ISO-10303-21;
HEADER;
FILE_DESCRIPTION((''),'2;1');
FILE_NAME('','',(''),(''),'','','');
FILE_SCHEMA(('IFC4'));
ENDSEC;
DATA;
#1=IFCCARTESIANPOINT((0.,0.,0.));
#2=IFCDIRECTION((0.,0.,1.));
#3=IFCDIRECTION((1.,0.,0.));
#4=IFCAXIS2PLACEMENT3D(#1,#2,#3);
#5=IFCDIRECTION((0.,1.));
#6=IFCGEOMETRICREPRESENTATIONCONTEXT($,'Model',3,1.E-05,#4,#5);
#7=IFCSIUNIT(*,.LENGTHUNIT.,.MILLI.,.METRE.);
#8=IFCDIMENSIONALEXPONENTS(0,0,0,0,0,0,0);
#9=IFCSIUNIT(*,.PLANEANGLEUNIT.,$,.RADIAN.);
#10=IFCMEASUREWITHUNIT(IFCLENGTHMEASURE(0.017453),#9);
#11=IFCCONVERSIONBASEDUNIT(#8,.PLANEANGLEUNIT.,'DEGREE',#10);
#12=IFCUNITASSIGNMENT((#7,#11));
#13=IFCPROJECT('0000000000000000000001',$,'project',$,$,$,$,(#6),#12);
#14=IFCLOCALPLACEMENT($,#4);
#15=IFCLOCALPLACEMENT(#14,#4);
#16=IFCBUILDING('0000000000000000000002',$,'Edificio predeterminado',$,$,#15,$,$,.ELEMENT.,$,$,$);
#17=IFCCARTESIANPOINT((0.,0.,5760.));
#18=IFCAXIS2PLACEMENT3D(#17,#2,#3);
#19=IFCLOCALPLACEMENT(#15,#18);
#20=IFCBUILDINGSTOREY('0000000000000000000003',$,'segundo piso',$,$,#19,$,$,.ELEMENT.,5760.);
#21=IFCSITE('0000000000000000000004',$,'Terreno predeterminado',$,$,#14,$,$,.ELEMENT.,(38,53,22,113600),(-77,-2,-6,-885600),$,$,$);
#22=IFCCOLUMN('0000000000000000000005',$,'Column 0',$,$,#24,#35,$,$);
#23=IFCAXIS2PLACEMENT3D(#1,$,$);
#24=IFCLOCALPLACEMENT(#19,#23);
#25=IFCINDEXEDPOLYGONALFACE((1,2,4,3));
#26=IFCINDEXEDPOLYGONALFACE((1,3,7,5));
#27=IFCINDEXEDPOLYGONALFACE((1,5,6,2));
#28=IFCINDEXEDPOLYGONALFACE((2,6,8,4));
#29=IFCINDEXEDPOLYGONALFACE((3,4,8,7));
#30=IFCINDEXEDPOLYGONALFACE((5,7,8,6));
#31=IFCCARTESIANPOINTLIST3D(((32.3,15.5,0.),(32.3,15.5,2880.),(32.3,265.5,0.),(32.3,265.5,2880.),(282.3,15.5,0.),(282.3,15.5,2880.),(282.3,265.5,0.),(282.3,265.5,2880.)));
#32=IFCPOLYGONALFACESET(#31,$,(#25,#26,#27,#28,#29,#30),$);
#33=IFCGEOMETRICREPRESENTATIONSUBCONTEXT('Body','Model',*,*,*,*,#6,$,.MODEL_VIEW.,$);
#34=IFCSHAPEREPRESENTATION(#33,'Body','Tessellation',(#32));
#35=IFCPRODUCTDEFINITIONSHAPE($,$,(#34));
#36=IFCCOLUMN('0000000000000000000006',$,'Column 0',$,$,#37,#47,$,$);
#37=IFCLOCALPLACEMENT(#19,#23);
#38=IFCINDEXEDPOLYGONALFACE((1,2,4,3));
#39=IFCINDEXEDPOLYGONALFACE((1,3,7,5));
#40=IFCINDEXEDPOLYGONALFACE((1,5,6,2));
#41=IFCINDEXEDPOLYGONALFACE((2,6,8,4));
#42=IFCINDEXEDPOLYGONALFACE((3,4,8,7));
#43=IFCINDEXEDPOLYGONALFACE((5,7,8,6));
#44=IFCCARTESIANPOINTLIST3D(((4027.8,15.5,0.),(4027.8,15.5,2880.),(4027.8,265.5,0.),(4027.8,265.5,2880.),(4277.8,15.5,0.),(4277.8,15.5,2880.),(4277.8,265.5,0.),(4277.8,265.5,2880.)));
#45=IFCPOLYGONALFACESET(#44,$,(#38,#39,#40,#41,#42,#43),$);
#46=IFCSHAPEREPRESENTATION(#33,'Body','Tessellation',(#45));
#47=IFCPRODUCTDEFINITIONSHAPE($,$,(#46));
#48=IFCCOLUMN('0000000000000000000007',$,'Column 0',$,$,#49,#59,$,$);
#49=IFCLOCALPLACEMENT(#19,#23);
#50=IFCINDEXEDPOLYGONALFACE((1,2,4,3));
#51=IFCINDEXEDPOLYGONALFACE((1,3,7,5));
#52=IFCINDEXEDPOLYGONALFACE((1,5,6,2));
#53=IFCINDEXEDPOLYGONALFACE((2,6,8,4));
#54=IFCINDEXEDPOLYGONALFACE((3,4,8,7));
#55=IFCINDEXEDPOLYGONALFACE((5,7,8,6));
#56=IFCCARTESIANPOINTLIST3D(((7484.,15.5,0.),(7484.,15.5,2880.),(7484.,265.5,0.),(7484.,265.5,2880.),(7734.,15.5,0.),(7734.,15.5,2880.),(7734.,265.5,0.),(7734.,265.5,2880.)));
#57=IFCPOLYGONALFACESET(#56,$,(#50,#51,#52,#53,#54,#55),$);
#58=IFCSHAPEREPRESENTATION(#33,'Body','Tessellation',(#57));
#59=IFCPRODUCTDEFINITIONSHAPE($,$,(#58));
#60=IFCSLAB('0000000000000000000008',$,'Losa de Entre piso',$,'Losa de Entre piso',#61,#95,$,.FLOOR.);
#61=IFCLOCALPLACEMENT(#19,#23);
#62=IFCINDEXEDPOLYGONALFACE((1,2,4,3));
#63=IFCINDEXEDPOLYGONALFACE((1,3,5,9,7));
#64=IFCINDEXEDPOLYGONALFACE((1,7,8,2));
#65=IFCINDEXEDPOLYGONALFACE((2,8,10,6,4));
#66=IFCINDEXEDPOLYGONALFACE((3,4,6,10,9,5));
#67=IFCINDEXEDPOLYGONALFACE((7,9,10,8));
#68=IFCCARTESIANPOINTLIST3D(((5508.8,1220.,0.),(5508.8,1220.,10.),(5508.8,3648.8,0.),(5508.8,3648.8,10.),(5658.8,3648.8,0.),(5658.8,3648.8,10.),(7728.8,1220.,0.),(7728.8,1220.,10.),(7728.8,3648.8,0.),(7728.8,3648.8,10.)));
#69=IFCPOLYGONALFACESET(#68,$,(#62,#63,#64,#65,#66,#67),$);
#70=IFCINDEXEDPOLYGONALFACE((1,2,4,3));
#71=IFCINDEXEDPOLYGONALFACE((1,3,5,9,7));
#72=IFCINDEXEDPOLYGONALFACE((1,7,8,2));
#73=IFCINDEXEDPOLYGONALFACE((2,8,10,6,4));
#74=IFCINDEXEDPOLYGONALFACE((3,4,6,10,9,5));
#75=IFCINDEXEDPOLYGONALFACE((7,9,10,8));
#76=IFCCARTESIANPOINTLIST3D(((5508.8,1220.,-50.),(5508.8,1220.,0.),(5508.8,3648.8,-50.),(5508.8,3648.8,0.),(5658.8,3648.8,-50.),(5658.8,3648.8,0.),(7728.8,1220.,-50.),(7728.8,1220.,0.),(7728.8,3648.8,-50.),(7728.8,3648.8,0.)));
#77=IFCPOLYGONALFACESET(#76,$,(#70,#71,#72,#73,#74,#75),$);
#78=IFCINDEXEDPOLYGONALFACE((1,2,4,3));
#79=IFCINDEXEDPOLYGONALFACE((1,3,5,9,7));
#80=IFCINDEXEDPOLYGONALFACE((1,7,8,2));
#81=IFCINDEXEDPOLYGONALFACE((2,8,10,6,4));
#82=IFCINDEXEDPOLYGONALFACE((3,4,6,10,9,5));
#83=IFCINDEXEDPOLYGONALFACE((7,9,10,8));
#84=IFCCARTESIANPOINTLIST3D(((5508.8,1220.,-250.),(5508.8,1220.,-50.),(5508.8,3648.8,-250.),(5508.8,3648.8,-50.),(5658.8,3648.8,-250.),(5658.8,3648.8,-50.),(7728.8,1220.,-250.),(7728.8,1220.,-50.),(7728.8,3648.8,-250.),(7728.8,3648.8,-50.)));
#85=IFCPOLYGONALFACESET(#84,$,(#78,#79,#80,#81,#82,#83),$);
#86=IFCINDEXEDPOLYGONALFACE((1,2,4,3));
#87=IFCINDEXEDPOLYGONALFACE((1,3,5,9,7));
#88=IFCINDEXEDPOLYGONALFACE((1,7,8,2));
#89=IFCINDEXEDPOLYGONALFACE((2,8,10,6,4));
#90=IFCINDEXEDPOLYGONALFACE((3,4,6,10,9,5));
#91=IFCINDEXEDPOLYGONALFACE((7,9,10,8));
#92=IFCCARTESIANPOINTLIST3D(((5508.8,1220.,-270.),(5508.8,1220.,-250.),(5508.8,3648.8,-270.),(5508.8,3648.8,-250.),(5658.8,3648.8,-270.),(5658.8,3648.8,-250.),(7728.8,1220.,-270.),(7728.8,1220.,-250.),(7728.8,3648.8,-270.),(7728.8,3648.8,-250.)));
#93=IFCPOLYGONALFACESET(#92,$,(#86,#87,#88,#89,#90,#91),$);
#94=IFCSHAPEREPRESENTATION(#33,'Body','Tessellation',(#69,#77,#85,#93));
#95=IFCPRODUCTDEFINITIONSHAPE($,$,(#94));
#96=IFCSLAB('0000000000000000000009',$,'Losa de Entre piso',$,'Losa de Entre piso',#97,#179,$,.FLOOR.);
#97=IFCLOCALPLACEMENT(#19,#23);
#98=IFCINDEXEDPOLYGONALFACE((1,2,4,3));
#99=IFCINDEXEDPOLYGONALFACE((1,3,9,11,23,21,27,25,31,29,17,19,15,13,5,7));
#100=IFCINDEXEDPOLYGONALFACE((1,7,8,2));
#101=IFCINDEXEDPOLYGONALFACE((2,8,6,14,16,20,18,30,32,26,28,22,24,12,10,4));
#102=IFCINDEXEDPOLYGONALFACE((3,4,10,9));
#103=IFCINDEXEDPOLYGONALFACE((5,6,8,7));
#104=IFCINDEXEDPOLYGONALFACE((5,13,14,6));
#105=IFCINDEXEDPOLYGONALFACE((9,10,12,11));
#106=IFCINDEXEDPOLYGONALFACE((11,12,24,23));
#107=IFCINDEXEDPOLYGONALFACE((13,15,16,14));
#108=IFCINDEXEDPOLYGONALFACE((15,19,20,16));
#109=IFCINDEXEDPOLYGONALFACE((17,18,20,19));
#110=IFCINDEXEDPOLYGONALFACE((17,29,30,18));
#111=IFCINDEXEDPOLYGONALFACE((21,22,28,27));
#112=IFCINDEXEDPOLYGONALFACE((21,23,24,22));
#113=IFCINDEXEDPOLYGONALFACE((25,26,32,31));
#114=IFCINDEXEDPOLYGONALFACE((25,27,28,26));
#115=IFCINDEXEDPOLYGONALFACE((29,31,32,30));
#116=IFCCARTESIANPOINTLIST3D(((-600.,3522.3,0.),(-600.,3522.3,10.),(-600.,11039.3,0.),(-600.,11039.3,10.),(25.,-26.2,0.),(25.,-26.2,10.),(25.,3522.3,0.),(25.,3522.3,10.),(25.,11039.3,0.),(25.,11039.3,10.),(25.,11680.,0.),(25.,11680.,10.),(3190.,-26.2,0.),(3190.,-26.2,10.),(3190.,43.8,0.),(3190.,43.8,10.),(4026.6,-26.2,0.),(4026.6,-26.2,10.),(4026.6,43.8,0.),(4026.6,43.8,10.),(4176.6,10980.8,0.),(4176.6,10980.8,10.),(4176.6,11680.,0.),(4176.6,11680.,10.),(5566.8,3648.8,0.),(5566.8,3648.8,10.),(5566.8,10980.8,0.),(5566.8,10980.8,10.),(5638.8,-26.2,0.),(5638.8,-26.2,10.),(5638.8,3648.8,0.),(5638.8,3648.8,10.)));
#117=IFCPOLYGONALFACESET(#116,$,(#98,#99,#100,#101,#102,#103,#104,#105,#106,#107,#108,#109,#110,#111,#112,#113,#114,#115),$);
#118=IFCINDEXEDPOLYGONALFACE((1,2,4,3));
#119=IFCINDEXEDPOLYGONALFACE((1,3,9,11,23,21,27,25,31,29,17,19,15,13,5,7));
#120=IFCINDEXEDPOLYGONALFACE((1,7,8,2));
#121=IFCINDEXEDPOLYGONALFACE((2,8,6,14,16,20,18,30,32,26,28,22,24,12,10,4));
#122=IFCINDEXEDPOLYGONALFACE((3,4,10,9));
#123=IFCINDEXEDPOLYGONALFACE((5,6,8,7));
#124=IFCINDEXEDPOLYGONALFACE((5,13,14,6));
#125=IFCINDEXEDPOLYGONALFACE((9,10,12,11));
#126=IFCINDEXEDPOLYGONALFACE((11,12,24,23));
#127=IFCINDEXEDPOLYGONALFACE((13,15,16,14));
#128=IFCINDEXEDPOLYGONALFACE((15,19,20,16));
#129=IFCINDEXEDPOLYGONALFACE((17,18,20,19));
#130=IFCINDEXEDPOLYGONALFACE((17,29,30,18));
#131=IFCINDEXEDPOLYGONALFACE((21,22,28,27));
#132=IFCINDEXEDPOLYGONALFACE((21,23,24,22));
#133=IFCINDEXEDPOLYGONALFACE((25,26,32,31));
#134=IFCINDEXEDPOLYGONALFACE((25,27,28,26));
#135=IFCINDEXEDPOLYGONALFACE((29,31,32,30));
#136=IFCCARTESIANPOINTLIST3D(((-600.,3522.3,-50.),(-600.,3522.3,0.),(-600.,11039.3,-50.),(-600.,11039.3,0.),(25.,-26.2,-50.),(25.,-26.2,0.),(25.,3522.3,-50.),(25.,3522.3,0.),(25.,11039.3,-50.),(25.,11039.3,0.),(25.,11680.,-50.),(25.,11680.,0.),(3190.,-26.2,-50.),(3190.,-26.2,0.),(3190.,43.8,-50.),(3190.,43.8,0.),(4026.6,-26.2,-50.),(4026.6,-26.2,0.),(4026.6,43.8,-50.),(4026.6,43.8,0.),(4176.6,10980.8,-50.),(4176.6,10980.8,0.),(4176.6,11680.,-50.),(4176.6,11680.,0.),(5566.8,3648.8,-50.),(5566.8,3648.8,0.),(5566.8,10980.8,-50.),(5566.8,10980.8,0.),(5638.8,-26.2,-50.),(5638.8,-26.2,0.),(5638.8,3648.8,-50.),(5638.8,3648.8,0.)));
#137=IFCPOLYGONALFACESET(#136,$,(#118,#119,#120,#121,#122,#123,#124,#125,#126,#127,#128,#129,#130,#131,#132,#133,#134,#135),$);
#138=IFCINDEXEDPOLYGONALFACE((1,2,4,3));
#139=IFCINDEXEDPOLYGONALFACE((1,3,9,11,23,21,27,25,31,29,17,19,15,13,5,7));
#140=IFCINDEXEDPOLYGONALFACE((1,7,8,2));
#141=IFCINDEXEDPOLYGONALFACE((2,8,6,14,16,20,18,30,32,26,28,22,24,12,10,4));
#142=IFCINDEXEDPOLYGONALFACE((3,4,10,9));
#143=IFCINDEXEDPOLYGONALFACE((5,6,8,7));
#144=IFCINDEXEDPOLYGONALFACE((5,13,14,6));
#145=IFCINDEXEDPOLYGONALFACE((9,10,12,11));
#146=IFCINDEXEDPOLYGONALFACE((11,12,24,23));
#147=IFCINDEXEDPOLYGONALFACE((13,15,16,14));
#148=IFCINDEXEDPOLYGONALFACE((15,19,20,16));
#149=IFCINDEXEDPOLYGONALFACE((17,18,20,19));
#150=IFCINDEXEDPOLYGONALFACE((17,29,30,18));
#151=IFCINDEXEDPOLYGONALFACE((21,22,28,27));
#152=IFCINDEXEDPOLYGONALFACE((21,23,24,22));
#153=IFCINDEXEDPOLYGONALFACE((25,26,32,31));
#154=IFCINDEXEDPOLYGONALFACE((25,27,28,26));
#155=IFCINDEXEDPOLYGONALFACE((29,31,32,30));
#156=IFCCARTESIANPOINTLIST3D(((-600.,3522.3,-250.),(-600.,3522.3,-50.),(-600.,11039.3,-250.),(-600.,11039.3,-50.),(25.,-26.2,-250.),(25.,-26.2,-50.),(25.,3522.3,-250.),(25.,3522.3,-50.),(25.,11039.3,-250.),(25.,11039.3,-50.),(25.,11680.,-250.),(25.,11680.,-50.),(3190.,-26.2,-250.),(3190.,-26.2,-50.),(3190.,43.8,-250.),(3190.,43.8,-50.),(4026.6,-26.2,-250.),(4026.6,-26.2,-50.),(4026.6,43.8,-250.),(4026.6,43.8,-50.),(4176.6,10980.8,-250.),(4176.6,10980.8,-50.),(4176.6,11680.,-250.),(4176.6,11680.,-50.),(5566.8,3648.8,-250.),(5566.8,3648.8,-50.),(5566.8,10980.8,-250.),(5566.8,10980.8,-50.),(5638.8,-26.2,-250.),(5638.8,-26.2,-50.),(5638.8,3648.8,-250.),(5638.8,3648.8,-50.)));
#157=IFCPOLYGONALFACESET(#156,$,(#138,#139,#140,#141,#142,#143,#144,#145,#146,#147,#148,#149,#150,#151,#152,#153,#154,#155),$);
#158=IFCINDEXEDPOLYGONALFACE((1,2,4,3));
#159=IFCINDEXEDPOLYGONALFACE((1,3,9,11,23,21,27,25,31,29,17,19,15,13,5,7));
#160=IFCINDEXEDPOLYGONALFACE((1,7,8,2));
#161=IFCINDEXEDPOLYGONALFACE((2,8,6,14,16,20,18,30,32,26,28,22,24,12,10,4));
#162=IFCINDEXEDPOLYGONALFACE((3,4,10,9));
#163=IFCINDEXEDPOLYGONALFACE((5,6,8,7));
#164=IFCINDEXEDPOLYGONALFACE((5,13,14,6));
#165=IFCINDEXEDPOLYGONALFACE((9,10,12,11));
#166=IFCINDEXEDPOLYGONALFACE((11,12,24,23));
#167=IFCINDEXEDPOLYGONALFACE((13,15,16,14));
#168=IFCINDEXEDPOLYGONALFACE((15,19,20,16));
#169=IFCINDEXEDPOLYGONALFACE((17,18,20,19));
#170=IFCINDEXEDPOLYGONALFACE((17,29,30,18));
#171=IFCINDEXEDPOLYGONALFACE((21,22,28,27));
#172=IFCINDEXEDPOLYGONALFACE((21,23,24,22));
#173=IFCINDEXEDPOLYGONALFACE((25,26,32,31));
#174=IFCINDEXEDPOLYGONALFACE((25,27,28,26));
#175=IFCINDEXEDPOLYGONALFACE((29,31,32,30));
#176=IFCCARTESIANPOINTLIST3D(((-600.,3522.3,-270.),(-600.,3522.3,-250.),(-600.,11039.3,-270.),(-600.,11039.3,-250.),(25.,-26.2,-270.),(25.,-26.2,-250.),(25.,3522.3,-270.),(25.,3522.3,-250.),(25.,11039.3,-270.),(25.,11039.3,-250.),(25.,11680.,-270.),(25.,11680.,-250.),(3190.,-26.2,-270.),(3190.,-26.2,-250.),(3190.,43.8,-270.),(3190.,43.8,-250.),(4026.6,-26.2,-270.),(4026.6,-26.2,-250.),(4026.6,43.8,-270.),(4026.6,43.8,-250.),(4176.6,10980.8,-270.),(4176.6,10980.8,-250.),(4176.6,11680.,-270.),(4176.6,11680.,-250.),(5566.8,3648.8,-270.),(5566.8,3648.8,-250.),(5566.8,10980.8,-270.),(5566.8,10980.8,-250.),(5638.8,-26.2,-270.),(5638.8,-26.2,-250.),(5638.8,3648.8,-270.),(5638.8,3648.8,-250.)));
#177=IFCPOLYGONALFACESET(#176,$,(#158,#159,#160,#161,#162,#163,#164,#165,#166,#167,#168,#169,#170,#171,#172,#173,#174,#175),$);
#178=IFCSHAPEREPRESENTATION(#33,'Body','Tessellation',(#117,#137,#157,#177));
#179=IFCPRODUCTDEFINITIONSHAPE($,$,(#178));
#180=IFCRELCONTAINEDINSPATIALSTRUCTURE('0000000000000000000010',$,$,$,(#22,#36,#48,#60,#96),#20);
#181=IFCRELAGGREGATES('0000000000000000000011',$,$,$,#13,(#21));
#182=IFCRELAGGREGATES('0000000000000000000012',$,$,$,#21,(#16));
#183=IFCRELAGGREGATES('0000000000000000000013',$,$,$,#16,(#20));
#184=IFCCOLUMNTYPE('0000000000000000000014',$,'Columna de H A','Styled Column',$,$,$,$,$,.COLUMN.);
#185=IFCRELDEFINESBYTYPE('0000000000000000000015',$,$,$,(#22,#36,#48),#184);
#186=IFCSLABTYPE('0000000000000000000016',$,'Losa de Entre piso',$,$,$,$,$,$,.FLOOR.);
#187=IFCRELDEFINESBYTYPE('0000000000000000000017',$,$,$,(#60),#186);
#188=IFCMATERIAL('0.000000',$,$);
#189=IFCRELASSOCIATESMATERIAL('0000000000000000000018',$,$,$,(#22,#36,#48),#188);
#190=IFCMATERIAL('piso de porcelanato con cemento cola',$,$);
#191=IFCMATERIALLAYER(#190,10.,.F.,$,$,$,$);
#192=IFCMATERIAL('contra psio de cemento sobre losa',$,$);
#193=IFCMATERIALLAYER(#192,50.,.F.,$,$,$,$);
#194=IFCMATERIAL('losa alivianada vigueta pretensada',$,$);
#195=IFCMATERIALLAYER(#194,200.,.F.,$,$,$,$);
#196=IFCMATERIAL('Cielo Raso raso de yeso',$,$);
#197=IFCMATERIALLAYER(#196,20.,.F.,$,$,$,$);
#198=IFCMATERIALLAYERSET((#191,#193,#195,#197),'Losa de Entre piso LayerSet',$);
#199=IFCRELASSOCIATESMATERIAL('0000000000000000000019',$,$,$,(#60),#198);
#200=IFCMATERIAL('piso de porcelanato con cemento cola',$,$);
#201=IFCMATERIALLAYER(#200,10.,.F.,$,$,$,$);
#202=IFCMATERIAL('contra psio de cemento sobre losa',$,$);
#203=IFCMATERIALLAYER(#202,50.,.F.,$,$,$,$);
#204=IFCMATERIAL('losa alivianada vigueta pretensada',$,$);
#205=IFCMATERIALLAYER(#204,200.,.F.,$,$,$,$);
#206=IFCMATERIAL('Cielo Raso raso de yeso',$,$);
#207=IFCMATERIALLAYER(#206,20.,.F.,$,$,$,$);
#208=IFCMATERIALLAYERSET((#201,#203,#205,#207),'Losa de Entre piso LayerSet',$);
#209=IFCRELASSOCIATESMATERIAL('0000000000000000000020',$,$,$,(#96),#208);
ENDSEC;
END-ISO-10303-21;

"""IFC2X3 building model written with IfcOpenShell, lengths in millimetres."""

from ifc_helpers import new_model, entity, si_unit, converted_unit, direction, frame, origin_with_axes, place, context, subcontext, project, spatial, polyline, outline, extrude, material, layer, layer_set, layer_usage, type_object, element, save


model = new_model("IFC2X3")

# Units and contexts
model_context = context("Model", 3, precision=1e-05, world=origin_with_axes(), true_north=direction((0.0, 1.0)))
body_context = subcontext(model_context, "Body", "Model", "MODEL_VIEW")
ifc_project = project(units=[si_unit("LENGTHUNIT", "METRE", prefix="MILLI"), converted_unit("PLANEANGLEUNIT", "DEGREE", entity("IfcLengthMeasure", 0.017453), si_unit("PLANEANGLEUNIT", "RADIAN"), dimensions=[0, 0, 0, 0, 0, 0, 0])], contexts=[model_context])

# Site, building, storey
site_placement = place(None, origin_with_axes())
site = spatial("IfcSite", under=ifc_project, at=site_placement, Name="Terreno predeterminado", CompositionType="ELEMENT", RefLatitude=(38, 53, 22, 113600), RefLongitude=(-77, -2, -6, -885600))
building_placement = place(site_placement, origin_with_axes())
building = spatial("IfcBuilding", under=site, at=building_placement, Name="Edificio predeterminado", CompositionType="ELEMENT")
storey_placement = place(building_placement, frame((0.0, 0.0, 5760.0), z_axis=(0.0, 0.0, 1.0), x_axis=(1.0, 0.0, 0.0)))
storey = spatial("IfcBuildingStorey", under=building, at=storey_placement, Name="segundo piso", CompositionType="ELEMENT", Elevation=5760.0)

# Columns
ifc_material_1 = material(Name="0.000000")
column_type = type_object("IfcColumnType", Name="Columna de H A", Description="Styled Column", PredefinedType="COLUMN")
for number, where, z_axis, x_axis, name in (
    (1, (157.3, 140.5, 0.0), (0.0, 0.0, 1.0), (1.0, 0.0, 0.0), "Column 0"),
    (2, (4152.8, 140.5, 0.0), (0.0, 0.0, 1.0), (1.0, 0.0, 0.0), "Column 0"),
    (3, (7609.0, 140.5, 0.0), (0.0, 0.0, 1.0), (1.0, 0.0, 0.0), "Column 0"),
):
    element("IfcColumn", number, at=place(storey_placement, frame(where, z_axis=z_axis, x_axis=x_axis)), inside=storey, type_object=column_type, material=ifc_material_1, Name=name, context=body_context, shape_type="SweptSolid", body=[
        extrude(outline(polyline([(-125.0, -125.0), (125.0, -125.0), (125.0, 125.0), (-125.0, 125.0), (-125.0, -125.0)])), origin_with_axes(), (0.0, 0.0, 1.0), 2880.0),
    ])

# Slabs
ifc_material_2 = material(Name="piso de porcelanato con cemento cola")
ifc_layer_1 = layer(ifc_material_2, 10.0, ventilated=False)
ifc_material_3 = material(Name="contra psio de cemento sobre losa")
ifc_layer_2 = layer(ifc_material_3, 50.0, ventilated=False)
ifc_material_4 = material(Name="losa alivianada vigueta pretensada")
ifc_layer_3 = layer(ifc_material_4, 200.0, ventilated=False)
ifc_material_5 = material(Name="Cielo Raso raso de yeso")
ifc_layer_4 = layer(ifc_material_5, 20.0, ventilated=False)
ifc_layer_set_1 = layer_set([ifc_layer_1, ifc_layer_2, ifc_layer_3, ifc_layer_4], Name="Losa de Entre piso LayerSet")
ifc_layer_usage_1 = layer_usage(ifc_layer_set_1, "AXIS3", "POSITIVE", 0.0)
slab_type = type_object("IfcSlabType", Name="Losa de Entre piso", PredefinedType="FLOOR")
slab_1_placement = place(storey_placement, frame((0.0, 0.0, -5760.0), z_axis=(0.0, 0.0, 1.0), x_axis=(1.0, 0.0, 0.0)))
element("IfcSlab", 4, at=slab_1_placement, inside=storey, type_object=slab_type, material=ifc_layer_usage_1, Name="Losa de Entre piso", ObjectType="Losa de Entre piso", PredefinedType="FLOOR", context=body_context, shape_type="SweptSolid", body=[
    extrude(outline(polyline([(0.0, 0.0), (2070.0, 0.0), (2070.0, 2428.8), (-150.0, 2428.8), (-150.0, 0.0), (0.0, 0.0)])), frame((5658.8, 3648.8, 5760.0), z_axis=(0.0, 0.0, -1.0), x_axis=(1.0, 0.0, 0.0)), (0.0, 0.0, -1.0), 10.0),
    extrude(outline(polyline([(0.0, 0.0), (2070.0, 0.0), (2070.0, 2428.8), (-150.0, 2428.8), (-150.0, 0.0), (0.0, 0.0)])), frame((5658.8, 3648.8, 5710.0), z_axis=(0.0, 0.0, -1.0), x_axis=(1.0, 0.0, 0.0)), (0.0, 0.0, -1.0), 50.0),
    extrude(outline(polyline([(0.0, 0.0), (2070.0, 0.0), (2070.0, 2428.8), (-150.0, 2428.8), (-150.0, 0.0), (0.0, 0.0)])), frame((5658.8, 3648.8, 5510.0), z_axis=(0.0, 0.0, -1.0), x_axis=(1.0, 0.0, 0.0)), (0.0, 0.0, -1.0), 200.0),
    extrude(outline(polyline([(0.0, 0.0), (2070.0, 0.0), (2070.0, 2428.8), (-150.0, 2428.8), (-150.0, 0.0), (0.0, 0.0)])), frame((5658.8, 3648.8, 5490.0), z_axis=(0.0, 0.0, -1.0), x_axis=(1.0, 0.0, 0.0)), (0.0, 0.0, -1.0), 20.0),
])
ifc_material_6 = material(Name="piso de porcelanato con cemento cola")
ifc_layer_5 = layer(ifc_material_6, 10.0, ventilated=False)
ifc_material_7 = material(Name="contra psio de cemento sobre losa")
ifc_layer_6 = layer(ifc_material_7, 50.0, ventilated=False)
ifc_material_8 = material(Name="losa alivianada vigueta pretensada")
ifc_layer_7 = layer(ifc_material_8, 200.0, ventilated=False)
ifc_material_9 = material(Name="Cielo Raso raso de yeso")
ifc_layer_8 = layer(ifc_material_9, 20.0, ventilated=False)
ifc_layer_set_2 = layer_set([ifc_layer_5, ifc_layer_6, ifc_layer_7, ifc_layer_8], Name="Losa de Entre piso LayerSet")
ifc_layer_usage_2 = layer_usage(ifc_layer_set_2, "AXIS3", "POSITIVE", 0.0)
slab_2_placement = place(storey_placement, frame((0.0, 0.0, -5760.0), z_axis=(0.0, 0.0, 1.0), x_axis=(1.0, 0.0, 0.0)))
element("IfcSlab", 5, at=slab_2_placement, inside=storey, material=ifc_layer_usage_2, Name="Losa de Entre piso", ObjectType="Losa de Entre piso", PredefinedType="FLOOR", context=body_context, shape_type="SweptSolid", body=[
    extrude(outline(polyline([(0.0, 0.0), (625.0, 0.0), (625.0, 7517.0), (0.0, 7517.0), (0.0, 8157.7), (-4151.6, 8157.7), (-4151.6, 7458.5), (-5541.8, 7458.5), (-5541.8, 126.5), (-5613.8, 126.5), (-5613.8, -3548.5), (-4001.6, -3548.5), (-4001.6, -3478.5), (-3165.0, -3478.5), (-3165.0, -3548.5), (0.0, -3548.5), (0.0, 0.0)])), frame((25.0, 3522.3, 5760.0), z_axis=(0.0, 0.0, -1.0), x_axis=(-1.0, 0.0, 0.0)), (0.0, 0.0, -1.0), 10.0),
    extrude(outline(polyline([(0.0, 0.0), (625.0, 0.0), (625.0, 7517.0), (0.0, 7517.0), (0.0, 8157.7), (-4151.6, 8157.7), (-4151.6, 7458.5), (-5541.8, 7458.5), (-5541.8, 126.5), (-5613.8, 126.5), (-5613.8, -3548.5), (-4001.6, -3548.5), (-4001.6, -3478.5), (-3165.0, -3478.5), (-3165.0, -3548.5), (0.0, -3548.5), (0.0, 0.0)])), frame((25.0, 3522.3, 5710.0), z_axis=(0.0, 0.0, -1.0), x_axis=(-1.0, 0.0, 0.0)), (0.0, 0.0, -1.0), 50.0),
    extrude(outline(polyline([(0.0, 0.0), (625.0, 0.0), (625.0, 7517.0), (0.0, 7517.0), (0.0, 8157.7), (-4151.6, 8157.7), (-4151.6, 7458.5), (-5541.8, 7458.5), (-5541.8, 126.5), (-5613.8, 126.5), (-5613.8, -3548.5), (-4001.6, -3548.5), (-4001.6, -3478.5), (-3165.0, -3478.5), (-3165.0, -3548.5), (0.0, -3548.5), (0.0, 0.0)])), frame((25.0, 3522.3, 5510.0), z_axis=(0.0, 0.0, -1.0), x_axis=(-1.0, 0.0, 0.0)), (0.0, 0.0, -1.0), 200.0),
    extrude(outline(polyline([(0.0, 0.0), (625.0, 0.0), (625.0, 7517.0), (0.0, 7517.0), (0.0, 8157.7), (-4151.6, 8157.7), (-4151.6, 7458.5), (-5541.8, 7458.5), (-5541.8, 126.5), (-5613.8, 126.5), (-5613.8, -3548.5), (-4001.6, -3548.5), (-4001.6, -3478.5), (-3165.0, -3478.5), (-3165.0, -3548.5), (0.0, -3548.5), (0.0, 0.0)])), frame((25.0, 3522.3, 5490.0), z_axis=(0.0, 0.0, -1.0), x_axis=(-1.0, 0.0, 0.0)), (0.0, 0.0, -1.0), 20.0),
])

save(model, "model.ifc")
